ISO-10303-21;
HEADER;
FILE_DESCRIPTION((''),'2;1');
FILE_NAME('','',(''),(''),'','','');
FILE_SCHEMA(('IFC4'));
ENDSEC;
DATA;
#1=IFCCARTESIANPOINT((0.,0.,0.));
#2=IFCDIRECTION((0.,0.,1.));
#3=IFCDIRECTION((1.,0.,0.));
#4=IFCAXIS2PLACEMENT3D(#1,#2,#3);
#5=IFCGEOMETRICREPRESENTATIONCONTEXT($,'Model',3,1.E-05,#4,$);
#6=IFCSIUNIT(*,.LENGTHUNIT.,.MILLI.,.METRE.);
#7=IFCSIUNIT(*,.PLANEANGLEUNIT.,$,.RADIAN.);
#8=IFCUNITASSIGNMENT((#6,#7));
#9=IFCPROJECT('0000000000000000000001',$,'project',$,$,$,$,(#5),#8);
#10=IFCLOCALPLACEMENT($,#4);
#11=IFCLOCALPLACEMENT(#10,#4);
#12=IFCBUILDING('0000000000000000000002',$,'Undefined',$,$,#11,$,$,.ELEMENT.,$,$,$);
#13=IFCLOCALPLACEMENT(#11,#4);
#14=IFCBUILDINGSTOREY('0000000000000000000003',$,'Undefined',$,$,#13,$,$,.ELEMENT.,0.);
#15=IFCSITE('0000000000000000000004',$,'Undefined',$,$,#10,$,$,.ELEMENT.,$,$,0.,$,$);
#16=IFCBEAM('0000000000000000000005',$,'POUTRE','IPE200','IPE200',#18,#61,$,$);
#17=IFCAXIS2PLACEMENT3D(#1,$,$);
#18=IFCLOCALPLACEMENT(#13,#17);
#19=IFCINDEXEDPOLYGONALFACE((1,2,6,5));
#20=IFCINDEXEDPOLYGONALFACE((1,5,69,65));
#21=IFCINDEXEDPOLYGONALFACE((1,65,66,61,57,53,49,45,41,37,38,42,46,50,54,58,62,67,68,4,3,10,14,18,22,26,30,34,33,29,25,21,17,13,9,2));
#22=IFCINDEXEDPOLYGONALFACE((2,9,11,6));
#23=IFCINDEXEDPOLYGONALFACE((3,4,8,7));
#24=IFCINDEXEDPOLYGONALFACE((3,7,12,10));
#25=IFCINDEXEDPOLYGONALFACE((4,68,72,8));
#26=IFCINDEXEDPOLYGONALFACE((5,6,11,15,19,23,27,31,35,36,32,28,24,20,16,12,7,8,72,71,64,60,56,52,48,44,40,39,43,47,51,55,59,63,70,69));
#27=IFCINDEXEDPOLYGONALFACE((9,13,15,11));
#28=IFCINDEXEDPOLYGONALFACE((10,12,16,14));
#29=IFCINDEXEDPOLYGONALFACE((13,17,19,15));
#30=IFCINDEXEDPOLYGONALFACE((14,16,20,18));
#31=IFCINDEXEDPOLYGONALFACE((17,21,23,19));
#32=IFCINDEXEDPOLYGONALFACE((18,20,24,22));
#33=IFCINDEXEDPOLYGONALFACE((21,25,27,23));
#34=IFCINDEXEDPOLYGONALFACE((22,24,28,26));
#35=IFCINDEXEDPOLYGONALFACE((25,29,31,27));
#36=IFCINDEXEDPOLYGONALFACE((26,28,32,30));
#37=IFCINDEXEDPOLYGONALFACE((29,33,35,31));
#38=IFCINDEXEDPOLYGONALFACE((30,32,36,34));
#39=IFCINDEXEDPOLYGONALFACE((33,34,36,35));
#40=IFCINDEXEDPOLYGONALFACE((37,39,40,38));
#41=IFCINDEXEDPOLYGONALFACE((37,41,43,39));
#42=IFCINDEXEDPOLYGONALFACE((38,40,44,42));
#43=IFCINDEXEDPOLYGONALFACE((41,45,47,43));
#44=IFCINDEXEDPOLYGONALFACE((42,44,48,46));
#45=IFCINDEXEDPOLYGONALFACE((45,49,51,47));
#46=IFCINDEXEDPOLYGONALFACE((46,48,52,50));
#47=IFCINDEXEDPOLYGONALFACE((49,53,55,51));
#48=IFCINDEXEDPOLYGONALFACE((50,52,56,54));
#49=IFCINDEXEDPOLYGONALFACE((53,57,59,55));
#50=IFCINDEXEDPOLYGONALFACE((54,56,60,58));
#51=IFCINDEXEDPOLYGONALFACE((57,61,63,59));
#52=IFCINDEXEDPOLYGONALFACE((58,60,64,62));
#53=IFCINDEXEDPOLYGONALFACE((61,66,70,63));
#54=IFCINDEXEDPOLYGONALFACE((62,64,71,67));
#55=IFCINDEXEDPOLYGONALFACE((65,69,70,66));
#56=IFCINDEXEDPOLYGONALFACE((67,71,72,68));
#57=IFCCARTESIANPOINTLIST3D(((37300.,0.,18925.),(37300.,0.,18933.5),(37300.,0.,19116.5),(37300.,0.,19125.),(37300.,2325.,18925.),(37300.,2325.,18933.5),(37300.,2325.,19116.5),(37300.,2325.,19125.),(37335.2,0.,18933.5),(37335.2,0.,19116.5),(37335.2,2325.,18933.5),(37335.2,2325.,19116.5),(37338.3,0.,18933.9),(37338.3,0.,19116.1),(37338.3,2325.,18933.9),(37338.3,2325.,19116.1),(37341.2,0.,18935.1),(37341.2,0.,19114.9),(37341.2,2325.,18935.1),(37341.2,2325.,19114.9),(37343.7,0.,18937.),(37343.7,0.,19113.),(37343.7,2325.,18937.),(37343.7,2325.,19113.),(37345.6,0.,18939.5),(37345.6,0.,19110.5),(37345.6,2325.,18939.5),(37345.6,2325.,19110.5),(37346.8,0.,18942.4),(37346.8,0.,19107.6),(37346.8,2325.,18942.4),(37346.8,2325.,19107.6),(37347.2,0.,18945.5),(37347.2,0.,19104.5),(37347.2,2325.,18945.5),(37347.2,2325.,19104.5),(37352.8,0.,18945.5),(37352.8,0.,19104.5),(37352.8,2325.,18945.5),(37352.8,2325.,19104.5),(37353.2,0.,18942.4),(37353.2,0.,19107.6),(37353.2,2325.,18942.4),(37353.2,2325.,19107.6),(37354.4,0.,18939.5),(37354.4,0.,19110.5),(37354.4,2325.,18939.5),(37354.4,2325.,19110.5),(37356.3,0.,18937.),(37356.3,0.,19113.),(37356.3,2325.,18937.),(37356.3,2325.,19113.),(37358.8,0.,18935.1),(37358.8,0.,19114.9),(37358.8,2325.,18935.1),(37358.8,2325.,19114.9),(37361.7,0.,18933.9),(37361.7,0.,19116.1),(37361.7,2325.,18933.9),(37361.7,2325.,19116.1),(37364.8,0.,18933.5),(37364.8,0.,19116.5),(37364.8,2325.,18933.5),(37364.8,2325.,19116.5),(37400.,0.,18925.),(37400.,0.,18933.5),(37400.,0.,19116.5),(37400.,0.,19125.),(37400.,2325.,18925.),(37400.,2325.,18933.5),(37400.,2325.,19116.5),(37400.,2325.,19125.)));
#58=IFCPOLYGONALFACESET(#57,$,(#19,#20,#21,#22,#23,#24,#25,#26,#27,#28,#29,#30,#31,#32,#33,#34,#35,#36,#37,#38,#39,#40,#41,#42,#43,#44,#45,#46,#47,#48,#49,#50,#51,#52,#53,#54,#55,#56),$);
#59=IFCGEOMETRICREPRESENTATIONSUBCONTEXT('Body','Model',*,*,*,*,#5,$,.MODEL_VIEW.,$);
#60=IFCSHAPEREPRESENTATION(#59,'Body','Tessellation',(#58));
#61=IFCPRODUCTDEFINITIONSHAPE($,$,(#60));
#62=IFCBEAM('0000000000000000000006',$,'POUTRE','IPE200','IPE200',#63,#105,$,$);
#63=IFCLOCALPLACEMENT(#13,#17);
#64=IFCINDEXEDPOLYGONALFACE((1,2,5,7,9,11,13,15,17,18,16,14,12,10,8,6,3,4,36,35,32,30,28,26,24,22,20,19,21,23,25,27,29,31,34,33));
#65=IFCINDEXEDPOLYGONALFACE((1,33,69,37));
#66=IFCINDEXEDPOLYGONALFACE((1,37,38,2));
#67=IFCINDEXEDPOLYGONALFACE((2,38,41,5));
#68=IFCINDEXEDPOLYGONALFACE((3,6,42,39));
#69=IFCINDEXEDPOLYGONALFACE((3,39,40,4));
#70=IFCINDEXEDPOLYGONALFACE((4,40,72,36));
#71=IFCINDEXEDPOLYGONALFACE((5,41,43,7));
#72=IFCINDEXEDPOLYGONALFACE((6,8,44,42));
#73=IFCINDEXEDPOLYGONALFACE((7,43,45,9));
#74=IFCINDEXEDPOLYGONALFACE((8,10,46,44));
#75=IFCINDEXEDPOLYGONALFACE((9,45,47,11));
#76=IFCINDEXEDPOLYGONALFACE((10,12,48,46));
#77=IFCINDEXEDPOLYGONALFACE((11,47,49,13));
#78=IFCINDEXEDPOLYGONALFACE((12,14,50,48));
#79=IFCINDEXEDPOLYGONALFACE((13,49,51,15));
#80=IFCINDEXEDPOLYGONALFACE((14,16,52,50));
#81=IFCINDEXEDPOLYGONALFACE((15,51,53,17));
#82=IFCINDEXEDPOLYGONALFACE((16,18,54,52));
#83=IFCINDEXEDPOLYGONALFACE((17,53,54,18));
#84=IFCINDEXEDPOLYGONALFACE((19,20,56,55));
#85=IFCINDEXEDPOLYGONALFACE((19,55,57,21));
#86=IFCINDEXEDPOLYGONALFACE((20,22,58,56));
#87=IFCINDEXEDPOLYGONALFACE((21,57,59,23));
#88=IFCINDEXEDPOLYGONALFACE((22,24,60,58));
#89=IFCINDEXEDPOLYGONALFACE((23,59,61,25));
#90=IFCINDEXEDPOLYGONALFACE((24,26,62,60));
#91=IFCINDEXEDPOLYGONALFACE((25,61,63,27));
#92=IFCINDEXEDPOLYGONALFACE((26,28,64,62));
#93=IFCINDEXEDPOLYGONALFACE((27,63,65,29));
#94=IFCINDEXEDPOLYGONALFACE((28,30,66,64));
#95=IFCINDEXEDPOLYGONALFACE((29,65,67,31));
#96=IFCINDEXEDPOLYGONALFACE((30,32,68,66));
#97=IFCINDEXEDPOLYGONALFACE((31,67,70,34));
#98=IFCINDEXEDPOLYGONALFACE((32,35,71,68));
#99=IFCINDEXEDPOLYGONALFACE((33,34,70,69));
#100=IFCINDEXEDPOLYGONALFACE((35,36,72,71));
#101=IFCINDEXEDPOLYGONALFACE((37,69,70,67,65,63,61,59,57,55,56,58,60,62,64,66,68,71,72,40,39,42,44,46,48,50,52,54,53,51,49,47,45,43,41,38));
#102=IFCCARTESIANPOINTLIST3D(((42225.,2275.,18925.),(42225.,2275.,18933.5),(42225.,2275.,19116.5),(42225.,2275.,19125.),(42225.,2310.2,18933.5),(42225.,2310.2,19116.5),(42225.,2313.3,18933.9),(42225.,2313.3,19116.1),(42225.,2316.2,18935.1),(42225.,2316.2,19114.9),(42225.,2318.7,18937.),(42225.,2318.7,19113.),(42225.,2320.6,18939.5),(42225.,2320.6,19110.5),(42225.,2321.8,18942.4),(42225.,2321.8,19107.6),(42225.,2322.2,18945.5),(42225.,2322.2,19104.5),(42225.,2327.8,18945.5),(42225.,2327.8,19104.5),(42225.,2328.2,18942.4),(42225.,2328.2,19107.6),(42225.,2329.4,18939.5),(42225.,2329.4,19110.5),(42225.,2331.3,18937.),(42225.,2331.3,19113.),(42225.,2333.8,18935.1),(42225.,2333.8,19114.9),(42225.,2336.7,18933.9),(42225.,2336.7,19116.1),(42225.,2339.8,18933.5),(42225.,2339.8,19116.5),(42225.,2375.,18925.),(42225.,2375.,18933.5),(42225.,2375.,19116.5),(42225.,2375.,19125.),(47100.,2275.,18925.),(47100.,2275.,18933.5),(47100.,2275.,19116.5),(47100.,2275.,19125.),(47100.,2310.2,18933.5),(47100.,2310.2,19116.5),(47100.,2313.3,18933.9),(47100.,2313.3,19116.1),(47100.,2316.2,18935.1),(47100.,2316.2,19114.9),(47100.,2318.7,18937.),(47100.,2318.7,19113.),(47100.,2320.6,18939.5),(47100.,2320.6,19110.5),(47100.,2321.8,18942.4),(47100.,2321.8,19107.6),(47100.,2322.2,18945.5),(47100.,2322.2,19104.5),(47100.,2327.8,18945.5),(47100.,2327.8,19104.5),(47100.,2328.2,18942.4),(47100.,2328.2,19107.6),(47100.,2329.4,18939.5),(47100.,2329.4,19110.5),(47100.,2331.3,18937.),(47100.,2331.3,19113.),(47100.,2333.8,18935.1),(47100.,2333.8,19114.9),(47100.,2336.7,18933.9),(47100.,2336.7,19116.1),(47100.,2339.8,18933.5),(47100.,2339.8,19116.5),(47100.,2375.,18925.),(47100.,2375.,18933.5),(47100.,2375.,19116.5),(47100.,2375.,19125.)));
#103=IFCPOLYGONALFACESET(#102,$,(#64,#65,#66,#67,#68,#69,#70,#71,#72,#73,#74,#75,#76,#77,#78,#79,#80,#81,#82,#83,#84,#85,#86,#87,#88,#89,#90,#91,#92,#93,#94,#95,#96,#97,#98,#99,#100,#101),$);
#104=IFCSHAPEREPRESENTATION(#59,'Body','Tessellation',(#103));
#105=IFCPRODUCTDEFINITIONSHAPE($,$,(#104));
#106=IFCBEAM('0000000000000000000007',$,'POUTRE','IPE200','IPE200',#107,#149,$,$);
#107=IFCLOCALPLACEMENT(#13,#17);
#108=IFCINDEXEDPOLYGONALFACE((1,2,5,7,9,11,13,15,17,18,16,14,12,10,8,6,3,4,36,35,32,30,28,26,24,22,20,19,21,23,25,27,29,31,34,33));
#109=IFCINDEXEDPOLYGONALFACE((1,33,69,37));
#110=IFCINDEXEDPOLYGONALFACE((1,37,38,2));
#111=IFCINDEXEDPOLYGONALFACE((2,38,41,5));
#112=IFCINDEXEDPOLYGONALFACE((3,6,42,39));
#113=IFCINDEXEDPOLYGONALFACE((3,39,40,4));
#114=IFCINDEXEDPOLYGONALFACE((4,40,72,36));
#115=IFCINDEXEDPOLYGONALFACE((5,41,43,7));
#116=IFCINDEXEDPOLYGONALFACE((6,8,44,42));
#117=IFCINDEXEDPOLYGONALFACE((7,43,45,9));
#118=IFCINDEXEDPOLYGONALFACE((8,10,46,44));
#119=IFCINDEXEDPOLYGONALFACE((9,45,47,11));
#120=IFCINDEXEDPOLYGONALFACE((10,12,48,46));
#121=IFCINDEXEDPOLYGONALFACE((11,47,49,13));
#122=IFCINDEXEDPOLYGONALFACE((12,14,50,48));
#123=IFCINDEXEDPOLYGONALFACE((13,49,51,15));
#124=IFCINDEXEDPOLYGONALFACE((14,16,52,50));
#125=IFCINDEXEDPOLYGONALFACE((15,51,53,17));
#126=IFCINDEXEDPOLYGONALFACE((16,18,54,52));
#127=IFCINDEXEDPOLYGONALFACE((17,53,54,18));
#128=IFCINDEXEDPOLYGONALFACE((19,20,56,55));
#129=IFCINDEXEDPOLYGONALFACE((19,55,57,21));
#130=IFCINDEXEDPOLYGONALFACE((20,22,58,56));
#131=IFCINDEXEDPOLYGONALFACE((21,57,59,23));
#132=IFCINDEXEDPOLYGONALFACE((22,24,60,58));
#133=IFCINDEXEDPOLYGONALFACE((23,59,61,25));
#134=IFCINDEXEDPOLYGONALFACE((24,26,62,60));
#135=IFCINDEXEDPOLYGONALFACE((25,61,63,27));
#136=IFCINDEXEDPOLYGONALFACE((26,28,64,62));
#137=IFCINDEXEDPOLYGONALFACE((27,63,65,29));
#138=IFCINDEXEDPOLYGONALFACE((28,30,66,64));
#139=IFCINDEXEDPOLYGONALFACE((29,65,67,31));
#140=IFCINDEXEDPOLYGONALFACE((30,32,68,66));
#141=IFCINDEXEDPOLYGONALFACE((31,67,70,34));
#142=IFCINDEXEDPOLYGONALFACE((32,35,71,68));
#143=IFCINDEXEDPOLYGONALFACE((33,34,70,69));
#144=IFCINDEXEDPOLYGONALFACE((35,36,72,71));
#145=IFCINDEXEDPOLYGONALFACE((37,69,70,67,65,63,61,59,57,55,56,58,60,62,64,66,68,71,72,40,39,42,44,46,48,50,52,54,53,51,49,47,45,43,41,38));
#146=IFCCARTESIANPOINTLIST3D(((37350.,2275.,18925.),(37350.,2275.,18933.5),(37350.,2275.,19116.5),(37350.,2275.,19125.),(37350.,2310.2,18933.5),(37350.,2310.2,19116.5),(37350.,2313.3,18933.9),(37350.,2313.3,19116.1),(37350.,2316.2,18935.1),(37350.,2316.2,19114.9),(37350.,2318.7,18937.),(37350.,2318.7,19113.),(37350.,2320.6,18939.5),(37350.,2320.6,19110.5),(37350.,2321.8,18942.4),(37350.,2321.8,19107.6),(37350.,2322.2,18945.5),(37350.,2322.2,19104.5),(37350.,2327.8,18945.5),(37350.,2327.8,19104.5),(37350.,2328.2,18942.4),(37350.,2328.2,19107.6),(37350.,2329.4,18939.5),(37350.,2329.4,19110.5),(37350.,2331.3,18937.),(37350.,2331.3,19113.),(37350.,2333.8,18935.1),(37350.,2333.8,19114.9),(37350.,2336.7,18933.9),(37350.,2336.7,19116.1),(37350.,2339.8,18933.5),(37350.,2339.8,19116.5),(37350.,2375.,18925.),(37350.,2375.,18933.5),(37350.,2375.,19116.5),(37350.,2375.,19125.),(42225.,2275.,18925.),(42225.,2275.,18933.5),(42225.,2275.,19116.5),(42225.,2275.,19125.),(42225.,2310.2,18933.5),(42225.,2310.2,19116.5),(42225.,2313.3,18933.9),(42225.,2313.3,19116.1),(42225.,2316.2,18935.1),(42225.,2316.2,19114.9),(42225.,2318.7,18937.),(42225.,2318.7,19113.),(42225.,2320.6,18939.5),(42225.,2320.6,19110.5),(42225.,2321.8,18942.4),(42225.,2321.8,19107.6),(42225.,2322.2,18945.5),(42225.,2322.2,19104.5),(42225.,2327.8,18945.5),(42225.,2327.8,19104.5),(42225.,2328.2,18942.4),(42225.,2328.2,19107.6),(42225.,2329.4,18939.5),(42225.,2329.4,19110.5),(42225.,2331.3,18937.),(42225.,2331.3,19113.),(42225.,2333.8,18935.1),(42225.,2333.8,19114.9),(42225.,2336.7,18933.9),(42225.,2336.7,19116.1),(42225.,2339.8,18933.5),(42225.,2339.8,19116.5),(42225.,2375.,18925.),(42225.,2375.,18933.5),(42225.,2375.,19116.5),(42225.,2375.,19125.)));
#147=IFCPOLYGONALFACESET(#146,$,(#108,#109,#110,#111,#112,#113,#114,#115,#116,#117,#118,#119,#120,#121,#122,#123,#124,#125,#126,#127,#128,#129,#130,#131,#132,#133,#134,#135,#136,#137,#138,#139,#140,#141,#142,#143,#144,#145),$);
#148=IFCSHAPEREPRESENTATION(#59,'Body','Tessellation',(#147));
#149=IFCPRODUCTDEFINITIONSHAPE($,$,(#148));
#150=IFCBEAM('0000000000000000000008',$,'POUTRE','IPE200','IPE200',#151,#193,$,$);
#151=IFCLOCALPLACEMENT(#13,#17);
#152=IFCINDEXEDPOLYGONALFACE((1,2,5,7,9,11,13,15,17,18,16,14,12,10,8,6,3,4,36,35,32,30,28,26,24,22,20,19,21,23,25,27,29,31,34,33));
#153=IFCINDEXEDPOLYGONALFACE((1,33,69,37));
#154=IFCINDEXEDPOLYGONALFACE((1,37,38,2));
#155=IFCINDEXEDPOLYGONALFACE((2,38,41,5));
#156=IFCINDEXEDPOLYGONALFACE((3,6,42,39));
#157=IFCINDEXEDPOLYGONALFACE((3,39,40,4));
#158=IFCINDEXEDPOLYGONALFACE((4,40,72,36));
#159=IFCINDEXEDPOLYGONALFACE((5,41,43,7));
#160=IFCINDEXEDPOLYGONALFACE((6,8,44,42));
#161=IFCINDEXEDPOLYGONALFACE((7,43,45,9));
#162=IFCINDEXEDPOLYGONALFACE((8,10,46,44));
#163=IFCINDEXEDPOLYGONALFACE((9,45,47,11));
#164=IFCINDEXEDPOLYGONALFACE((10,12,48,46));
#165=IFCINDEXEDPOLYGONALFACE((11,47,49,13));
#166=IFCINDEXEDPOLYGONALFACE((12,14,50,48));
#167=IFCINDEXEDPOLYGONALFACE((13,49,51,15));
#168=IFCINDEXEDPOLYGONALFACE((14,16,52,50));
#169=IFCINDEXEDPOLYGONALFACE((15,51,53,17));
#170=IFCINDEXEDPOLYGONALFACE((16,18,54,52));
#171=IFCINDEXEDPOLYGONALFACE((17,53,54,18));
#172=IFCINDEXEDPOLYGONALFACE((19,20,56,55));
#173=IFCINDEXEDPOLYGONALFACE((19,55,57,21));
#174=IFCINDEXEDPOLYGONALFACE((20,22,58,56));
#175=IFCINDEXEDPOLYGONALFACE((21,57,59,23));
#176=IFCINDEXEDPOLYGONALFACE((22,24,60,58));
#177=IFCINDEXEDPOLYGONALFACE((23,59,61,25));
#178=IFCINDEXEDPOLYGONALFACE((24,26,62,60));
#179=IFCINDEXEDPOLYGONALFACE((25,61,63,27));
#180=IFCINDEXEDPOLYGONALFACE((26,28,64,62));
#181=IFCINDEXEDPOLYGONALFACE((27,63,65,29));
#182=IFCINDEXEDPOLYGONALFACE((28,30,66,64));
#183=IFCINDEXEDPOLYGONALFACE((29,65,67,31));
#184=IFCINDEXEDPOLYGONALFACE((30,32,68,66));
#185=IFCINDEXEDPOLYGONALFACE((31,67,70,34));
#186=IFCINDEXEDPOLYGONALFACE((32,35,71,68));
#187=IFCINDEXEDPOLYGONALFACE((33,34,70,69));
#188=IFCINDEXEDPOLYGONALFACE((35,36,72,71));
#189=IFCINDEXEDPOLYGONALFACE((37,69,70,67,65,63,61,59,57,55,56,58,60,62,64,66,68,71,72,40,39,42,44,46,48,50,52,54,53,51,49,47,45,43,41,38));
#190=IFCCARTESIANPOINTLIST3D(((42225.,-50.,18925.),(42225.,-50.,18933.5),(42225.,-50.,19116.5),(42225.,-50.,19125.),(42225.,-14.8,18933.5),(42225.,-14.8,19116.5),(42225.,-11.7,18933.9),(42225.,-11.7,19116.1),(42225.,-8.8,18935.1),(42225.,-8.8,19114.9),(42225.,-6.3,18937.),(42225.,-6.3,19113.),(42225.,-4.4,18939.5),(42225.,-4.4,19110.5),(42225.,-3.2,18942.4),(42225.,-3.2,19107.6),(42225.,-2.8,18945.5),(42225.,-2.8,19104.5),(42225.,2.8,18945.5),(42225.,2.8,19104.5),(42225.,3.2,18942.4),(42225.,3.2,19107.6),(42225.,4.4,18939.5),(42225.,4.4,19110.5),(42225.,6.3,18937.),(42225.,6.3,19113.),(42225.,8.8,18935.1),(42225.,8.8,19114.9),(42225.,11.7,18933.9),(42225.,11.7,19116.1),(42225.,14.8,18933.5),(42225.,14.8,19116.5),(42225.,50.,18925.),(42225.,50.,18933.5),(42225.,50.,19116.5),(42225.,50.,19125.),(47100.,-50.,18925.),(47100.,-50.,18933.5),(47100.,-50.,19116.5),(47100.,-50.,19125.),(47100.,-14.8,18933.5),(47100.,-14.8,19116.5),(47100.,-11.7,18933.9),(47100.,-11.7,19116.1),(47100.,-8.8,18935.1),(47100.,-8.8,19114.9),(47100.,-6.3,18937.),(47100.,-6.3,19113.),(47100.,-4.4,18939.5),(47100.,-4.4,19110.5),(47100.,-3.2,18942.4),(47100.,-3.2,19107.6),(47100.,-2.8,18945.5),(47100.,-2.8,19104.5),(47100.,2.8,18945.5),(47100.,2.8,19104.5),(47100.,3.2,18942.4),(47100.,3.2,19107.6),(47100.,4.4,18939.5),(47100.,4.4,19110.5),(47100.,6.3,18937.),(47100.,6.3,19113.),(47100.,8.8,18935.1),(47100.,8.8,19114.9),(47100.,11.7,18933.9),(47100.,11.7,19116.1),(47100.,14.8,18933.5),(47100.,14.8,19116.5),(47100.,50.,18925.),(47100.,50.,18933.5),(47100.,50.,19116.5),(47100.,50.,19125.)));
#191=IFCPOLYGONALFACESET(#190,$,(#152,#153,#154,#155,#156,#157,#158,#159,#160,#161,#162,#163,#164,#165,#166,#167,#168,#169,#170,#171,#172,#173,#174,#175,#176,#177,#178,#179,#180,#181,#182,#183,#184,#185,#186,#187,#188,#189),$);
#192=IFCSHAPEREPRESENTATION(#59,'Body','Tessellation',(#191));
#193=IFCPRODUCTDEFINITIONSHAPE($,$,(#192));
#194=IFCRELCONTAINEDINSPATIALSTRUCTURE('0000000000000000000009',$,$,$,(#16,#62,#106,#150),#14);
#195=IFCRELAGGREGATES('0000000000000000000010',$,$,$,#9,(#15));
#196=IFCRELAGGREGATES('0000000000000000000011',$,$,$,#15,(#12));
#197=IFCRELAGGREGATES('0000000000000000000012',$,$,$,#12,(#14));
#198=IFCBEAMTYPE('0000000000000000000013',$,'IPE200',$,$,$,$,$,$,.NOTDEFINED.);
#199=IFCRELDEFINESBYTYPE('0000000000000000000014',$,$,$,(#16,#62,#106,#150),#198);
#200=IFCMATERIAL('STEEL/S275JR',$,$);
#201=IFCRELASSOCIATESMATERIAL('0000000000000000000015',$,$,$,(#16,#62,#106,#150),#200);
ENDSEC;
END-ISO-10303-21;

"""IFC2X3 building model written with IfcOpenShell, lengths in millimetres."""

from ifc_helpers import new_model, si_unit, frame, origin_with_axes, origin_2d_with_axis, place, context, subcontext, project, spatial, i_section, extrude, material, type_object, element, save


model = new_model("IFC2X3")

# Units and contexts
model_context = context("Model", 3, precision=1e-05, world=origin_with_axes())
body_context = subcontext(model_context, "Body", "Model", "MODEL_VIEW")
ifc_project = project(units=[si_unit("LENGTHUNIT", "METRE", prefix="MILLI"), si_unit("PLANEANGLEUNIT", "RADIAN")], contexts=[model_context])

# Site, building, storey
site_placement = place(None, origin_with_axes())
site = spatial("IfcSite", under=ifc_project, at=site_placement, Name="Undefined", CompositionType="ELEMENT", RefElevation=0.0)
building_placement = place(site_placement, origin_with_axes())
building = spatial("IfcBuilding", under=site, at=building_placement, Name="Undefined", CompositionType="ELEMENT")
storey_placement = place(building_placement, origin_with_axes())
storey = spatial("IfcBuildingStorey", under=building, at=storey_placement, Name="Undefined", CompositionType="ELEMENT", Elevation=0.0)

# Shared definitions
ifc_material_1 = material(Name="STEEL/S275JR")

# Beams
beam_type_1 = type_object("IfcBeamType", Name="IPE200", PredefinedType="NOTDEFINED")
for number, where, z_axis, x_axis, name in (
    (1, (37350.0, 0.0, 19025.0), (0.0, 0.000013, 1.0), (0.0, 1.0, -0.000013), "POUTRE"),
):
    element("IfcBeam", number, at=place(storey_placement, frame(where, z_axis=z_axis, x_axis=x_axis)), inside=storey, type_object=beam_type_1, material=ifc_material_1, Name=name, Description="IPE200", ObjectType="IPE200", context=body_context, shape_type="SweptSolid", body=[
        extrude(i_section(OverallWidth=100.0, OverallDepth=200.0, WebThickness=5.6, FlangeThickness=8.5, FilletRadius=12.0, at=origin_2d_with_axis()), frame((2325.0, 0.0, 0.0), z_axis=(-1.0, 0.0, 0.0), x_axis=(0.0, -1.0, 0.0)), (0.0, 0.0, 1.0), 2325.0),
    ])
beam_1_placement = place(storey_placement, frame((42225.0, 2325.0, 19025.0), z_axis=(0.0, 0.0, 1.0), x_axis=(1.0, 0.0, 0.0)))
element("IfcBeam", 2, at=beam_1_placement, inside=storey, type_object=beam_type_1, material=ifc_material_1, Name="POUTRE", Description="IPE200", ObjectType="IPE200", context=body_context, shape_type="SweptSolid", body=[
    extrude(i_section(OverallWidth=100.0, OverallDepth=200.0, WebThickness=5.6, FlangeThickness=8.5, FilletRadius=12.0, at=origin_2d_with_axis()), frame((4875.0, 0.0, 0.0), z_axis=(-1.0, 0.0, 0.0), x_axis=(0.0, -1.0, 0.0)), (0.0, 0.0, 1.0), 4875.0),
])
beam_2_placement = place(storey_placement, frame((37350.0, 2325.0, 19025.0), z_axis=(0.0, 0.0, 1.0), x_axis=(1.0, 0.0, 0.0)))
element("IfcBeam", 3, at=beam_2_placement, inside=storey, type_object=beam_type_1, material=ifc_material_1, Name="POUTRE", Description="IPE200", ObjectType="IPE200", context=body_context, shape_type="SweptSolid", body=[
    extrude(i_section(OverallWidth=100.0, OverallDepth=200.0, WebThickness=5.6, FlangeThickness=8.5, FilletRadius=12.0, at=origin_2d_with_axis()), frame((4875.0, 0.0, 0.0), z_axis=(-1.0, 0.0, 0.0), x_axis=(0.0, -1.0, 0.0)), (0.0, 0.0, 1.0), 4875.0),
])
for number, where, z_axis, x_axis, name in (
    (4, (42225.0, 0.0, 19025.0), (0.000006, 0.0, 1.0), (1.0, 0.0, -0.000006), "POUTRE"),
):
    element("IfcBeam", number, at=place(storey_placement, frame(where, z_axis=z_axis, x_axis=x_axis)), inside=storey, type_object=beam_type_1, material=ifc_material_1, Name=name, Description="IPE200", ObjectType="IPE200", context=body_context, shape_type="SweptSolid", body=[
        extrude(i_section(OverallWidth=100.0, OverallDepth=200.0, WebThickness=5.6, FlangeThickness=8.5, FilletRadius=12.0, at=origin_2d_with_axis()), frame((4875.0, 0.0, 0.0), z_axis=(-1.0, 0.0, 0.0), x_axis=(0.0, -1.0, 0.0)), (0.0, 0.0, 1.0), 4875.0),
    ])

save(model, "model.ifc")
